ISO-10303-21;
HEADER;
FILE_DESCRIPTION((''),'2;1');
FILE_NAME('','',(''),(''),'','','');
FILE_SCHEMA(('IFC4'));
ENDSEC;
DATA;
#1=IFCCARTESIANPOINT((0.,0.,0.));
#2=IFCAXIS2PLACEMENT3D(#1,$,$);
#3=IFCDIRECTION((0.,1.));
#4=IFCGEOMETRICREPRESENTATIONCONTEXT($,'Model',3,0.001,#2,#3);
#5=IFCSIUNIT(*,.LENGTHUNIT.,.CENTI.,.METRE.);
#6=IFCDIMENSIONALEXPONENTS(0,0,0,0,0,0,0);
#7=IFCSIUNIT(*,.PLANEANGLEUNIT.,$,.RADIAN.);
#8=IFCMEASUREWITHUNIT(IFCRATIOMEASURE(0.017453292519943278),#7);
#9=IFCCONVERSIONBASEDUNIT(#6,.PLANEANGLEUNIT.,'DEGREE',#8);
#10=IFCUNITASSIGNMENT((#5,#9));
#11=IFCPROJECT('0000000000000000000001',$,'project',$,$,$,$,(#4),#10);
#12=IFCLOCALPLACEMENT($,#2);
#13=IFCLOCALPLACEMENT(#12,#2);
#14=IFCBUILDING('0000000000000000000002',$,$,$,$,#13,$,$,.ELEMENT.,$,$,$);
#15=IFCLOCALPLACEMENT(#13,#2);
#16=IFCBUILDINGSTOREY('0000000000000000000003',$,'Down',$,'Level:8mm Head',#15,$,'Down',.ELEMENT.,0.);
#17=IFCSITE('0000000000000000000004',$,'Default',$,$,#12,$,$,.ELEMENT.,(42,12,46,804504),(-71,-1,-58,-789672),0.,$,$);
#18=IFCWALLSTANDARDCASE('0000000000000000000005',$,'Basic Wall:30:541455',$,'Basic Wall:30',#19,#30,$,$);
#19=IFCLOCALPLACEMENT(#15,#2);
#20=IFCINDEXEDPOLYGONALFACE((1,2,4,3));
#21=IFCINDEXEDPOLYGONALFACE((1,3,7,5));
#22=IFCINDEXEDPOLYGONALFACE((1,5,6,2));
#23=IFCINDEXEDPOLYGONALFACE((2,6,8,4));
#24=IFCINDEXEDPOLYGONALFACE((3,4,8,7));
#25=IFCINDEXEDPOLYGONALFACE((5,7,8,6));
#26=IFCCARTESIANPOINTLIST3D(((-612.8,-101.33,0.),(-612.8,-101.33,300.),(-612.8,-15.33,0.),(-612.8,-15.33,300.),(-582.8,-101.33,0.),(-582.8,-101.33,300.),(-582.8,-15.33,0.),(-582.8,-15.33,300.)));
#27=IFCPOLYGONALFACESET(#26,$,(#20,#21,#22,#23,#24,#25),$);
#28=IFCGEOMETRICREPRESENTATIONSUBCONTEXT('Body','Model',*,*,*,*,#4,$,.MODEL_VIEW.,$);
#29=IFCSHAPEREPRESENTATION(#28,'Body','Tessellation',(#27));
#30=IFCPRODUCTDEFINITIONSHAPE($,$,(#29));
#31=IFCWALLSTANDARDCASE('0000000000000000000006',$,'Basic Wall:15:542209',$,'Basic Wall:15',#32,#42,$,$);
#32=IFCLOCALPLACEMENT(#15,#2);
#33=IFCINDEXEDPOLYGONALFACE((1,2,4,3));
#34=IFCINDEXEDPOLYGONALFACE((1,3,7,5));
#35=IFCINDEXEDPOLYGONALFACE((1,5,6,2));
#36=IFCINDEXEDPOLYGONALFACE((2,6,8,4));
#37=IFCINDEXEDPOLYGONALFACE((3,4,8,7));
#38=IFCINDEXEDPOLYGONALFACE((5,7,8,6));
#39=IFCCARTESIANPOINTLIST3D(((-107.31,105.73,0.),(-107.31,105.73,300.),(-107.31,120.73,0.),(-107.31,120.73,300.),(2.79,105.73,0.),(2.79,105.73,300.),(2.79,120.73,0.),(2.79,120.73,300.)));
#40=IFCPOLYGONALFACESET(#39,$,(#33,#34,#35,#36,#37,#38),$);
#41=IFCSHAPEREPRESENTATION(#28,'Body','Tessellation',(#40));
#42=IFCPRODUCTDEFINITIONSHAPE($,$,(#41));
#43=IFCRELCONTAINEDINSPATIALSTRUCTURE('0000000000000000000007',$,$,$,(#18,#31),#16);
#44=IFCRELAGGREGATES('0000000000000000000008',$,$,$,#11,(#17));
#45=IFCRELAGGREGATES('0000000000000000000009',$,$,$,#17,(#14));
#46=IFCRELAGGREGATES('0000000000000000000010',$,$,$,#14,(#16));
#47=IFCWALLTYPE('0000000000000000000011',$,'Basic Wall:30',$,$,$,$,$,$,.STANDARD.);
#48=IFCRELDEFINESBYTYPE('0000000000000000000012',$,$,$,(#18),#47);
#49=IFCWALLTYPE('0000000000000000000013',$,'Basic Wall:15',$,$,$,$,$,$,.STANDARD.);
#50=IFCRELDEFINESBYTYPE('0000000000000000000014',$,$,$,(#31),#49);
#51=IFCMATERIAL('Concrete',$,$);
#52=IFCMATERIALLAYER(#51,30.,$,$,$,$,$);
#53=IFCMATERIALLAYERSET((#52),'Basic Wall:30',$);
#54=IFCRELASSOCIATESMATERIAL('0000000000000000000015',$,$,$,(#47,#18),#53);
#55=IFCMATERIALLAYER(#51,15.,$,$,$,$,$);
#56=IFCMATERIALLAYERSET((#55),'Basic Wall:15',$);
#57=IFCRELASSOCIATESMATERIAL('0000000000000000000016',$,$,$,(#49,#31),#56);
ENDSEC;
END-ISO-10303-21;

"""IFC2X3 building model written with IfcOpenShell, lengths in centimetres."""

from ifc_helpers import new_model, entity, si_unit, converted_unit, direction, frame, frame_2d, origin, place, context, subcontext, project, spatial, rectangle, extrude, material, layer, layer_set, layer_usage, type_object, element, save


model = new_model("IFC2X3")

# Units and contexts
model_context = context("Model", 3, precision=0.001, world=origin(), true_north=direction((0.0, 1.0)))
body_context = subcontext(model_context, "Body", "Model", "MODEL_VIEW")
ifc_project = project(units=[si_unit("LENGTHUNIT", "METRE", prefix="CENTI"), converted_unit("PLANEANGLEUNIT", "DEGREE", entity("IfcRatioMeasure", 0.017453292519943278), si_unit("PLANEANGLEUNIT", "RADIAN"), dimensions=[0, 0, 0, 0, 0, 0, 0])], contexts=[model_context])

# Site, building, storey
site_placement = place(None, origin())
site = spatial("IfcSite", under=ifc_project, at=site_placement, Name="Default", CompositionType="ELEMENT", RefLatitude=(42, 12, 46, 804504), RefLongitude=(-71, -1, -58, -789672), RefElevation=0.0)
building_placement = place(site_placement, origin())
building = spatial("IfcBuilding", under=site, at=building_placement, CompositionType="ELEMENT")
storey_placement = place(building_placement, origin())
storey = spatial("IfcBuildingStorey", under=building, at=storey_placement, Name="Down", ObjectType="Level:8mm Head", LongName="Down", CompositionType="ELEMENT", Elevation=0.0)

# Shared definitions
ifc_material = material(Name="Concrete")

# Walls
ifc_layer_1 = layer(ifc_material, 30.0)
ifc_layer_set_1 = layer_set([ifc_layer_1], Name="Basic Wall:30")
ifc_layer_usage_1 = layer_usage(ifc_layer_set_1, "AXIS2", "POSITIVE", -15.0)
wall_type_1 = type_object("IfcWallType", Name="Basic Wall:30", PredefinedType="STANDARD", material=ifc_layer_set_1)
wall_1_placement = place(storey_placement, frame((-597.8, -15.33, 0.0), z_axis=(0.0, 0.0, 1.0), x_axis=(0.0, -1.0, 0.0)))
element("IfcWallStandardCase", 1, at=wall_1_placement, inside=storey, type_object=wall_type_1, material=ifc_layer_usage_1, Name="Basic Wall:30:541455", ObjectType="Basic Wall:30", context=body_context, shape_type="SweptSolid", body=[
    extrude(rectangle(XDim=86.0, YDim=30.0, at=frame_2d((43.0, 0.0), x_axis=(-1.0, 0.0))), origin(), (0.0, 0.0, 1.0), 300.0),
])
ifc_layer_2 = layer(ifc_material, 15.0)
ifc_layer_set_2 = layer_set([ifc_layer_2], Name="Basic Wall:15")
ifc_layer_usage_2 = layer_usage(ifc_layer_set_2, "AXIS2", "NEGATIVE", 7.5)
wall_type_2 = type_object("IfcWallType", Name="Basic Wall:15", PredefinedType="STANDARD", material=ifc_layer_set_2)
wall_2_placement = place(storey_placement, frame((2.79, 113.23, 0.0), z_axis=(0.0, 0.0, 1.0), x_axis=(-1.0, 0.0, 0.0)))
element("IfcWallStandardCase", 2, at=wall_2_placement, inside=storey, type_object=wall_type_2, material=ifc_layer_usage_2, Name="Basic Wall:15:542209", ObjectType="Basic Wall:15", context=body_context, shape_type="SweptSolid", body=[
    extrude(rectangle(XDim=110.1, YDim=15.0, at=frame_2d((55.05, 0.0), x_axis=(-1.0, 0.0))), origin(), (0.0, 0.0, 1.0), 300.0),
])

save(model, "model.ifc")
